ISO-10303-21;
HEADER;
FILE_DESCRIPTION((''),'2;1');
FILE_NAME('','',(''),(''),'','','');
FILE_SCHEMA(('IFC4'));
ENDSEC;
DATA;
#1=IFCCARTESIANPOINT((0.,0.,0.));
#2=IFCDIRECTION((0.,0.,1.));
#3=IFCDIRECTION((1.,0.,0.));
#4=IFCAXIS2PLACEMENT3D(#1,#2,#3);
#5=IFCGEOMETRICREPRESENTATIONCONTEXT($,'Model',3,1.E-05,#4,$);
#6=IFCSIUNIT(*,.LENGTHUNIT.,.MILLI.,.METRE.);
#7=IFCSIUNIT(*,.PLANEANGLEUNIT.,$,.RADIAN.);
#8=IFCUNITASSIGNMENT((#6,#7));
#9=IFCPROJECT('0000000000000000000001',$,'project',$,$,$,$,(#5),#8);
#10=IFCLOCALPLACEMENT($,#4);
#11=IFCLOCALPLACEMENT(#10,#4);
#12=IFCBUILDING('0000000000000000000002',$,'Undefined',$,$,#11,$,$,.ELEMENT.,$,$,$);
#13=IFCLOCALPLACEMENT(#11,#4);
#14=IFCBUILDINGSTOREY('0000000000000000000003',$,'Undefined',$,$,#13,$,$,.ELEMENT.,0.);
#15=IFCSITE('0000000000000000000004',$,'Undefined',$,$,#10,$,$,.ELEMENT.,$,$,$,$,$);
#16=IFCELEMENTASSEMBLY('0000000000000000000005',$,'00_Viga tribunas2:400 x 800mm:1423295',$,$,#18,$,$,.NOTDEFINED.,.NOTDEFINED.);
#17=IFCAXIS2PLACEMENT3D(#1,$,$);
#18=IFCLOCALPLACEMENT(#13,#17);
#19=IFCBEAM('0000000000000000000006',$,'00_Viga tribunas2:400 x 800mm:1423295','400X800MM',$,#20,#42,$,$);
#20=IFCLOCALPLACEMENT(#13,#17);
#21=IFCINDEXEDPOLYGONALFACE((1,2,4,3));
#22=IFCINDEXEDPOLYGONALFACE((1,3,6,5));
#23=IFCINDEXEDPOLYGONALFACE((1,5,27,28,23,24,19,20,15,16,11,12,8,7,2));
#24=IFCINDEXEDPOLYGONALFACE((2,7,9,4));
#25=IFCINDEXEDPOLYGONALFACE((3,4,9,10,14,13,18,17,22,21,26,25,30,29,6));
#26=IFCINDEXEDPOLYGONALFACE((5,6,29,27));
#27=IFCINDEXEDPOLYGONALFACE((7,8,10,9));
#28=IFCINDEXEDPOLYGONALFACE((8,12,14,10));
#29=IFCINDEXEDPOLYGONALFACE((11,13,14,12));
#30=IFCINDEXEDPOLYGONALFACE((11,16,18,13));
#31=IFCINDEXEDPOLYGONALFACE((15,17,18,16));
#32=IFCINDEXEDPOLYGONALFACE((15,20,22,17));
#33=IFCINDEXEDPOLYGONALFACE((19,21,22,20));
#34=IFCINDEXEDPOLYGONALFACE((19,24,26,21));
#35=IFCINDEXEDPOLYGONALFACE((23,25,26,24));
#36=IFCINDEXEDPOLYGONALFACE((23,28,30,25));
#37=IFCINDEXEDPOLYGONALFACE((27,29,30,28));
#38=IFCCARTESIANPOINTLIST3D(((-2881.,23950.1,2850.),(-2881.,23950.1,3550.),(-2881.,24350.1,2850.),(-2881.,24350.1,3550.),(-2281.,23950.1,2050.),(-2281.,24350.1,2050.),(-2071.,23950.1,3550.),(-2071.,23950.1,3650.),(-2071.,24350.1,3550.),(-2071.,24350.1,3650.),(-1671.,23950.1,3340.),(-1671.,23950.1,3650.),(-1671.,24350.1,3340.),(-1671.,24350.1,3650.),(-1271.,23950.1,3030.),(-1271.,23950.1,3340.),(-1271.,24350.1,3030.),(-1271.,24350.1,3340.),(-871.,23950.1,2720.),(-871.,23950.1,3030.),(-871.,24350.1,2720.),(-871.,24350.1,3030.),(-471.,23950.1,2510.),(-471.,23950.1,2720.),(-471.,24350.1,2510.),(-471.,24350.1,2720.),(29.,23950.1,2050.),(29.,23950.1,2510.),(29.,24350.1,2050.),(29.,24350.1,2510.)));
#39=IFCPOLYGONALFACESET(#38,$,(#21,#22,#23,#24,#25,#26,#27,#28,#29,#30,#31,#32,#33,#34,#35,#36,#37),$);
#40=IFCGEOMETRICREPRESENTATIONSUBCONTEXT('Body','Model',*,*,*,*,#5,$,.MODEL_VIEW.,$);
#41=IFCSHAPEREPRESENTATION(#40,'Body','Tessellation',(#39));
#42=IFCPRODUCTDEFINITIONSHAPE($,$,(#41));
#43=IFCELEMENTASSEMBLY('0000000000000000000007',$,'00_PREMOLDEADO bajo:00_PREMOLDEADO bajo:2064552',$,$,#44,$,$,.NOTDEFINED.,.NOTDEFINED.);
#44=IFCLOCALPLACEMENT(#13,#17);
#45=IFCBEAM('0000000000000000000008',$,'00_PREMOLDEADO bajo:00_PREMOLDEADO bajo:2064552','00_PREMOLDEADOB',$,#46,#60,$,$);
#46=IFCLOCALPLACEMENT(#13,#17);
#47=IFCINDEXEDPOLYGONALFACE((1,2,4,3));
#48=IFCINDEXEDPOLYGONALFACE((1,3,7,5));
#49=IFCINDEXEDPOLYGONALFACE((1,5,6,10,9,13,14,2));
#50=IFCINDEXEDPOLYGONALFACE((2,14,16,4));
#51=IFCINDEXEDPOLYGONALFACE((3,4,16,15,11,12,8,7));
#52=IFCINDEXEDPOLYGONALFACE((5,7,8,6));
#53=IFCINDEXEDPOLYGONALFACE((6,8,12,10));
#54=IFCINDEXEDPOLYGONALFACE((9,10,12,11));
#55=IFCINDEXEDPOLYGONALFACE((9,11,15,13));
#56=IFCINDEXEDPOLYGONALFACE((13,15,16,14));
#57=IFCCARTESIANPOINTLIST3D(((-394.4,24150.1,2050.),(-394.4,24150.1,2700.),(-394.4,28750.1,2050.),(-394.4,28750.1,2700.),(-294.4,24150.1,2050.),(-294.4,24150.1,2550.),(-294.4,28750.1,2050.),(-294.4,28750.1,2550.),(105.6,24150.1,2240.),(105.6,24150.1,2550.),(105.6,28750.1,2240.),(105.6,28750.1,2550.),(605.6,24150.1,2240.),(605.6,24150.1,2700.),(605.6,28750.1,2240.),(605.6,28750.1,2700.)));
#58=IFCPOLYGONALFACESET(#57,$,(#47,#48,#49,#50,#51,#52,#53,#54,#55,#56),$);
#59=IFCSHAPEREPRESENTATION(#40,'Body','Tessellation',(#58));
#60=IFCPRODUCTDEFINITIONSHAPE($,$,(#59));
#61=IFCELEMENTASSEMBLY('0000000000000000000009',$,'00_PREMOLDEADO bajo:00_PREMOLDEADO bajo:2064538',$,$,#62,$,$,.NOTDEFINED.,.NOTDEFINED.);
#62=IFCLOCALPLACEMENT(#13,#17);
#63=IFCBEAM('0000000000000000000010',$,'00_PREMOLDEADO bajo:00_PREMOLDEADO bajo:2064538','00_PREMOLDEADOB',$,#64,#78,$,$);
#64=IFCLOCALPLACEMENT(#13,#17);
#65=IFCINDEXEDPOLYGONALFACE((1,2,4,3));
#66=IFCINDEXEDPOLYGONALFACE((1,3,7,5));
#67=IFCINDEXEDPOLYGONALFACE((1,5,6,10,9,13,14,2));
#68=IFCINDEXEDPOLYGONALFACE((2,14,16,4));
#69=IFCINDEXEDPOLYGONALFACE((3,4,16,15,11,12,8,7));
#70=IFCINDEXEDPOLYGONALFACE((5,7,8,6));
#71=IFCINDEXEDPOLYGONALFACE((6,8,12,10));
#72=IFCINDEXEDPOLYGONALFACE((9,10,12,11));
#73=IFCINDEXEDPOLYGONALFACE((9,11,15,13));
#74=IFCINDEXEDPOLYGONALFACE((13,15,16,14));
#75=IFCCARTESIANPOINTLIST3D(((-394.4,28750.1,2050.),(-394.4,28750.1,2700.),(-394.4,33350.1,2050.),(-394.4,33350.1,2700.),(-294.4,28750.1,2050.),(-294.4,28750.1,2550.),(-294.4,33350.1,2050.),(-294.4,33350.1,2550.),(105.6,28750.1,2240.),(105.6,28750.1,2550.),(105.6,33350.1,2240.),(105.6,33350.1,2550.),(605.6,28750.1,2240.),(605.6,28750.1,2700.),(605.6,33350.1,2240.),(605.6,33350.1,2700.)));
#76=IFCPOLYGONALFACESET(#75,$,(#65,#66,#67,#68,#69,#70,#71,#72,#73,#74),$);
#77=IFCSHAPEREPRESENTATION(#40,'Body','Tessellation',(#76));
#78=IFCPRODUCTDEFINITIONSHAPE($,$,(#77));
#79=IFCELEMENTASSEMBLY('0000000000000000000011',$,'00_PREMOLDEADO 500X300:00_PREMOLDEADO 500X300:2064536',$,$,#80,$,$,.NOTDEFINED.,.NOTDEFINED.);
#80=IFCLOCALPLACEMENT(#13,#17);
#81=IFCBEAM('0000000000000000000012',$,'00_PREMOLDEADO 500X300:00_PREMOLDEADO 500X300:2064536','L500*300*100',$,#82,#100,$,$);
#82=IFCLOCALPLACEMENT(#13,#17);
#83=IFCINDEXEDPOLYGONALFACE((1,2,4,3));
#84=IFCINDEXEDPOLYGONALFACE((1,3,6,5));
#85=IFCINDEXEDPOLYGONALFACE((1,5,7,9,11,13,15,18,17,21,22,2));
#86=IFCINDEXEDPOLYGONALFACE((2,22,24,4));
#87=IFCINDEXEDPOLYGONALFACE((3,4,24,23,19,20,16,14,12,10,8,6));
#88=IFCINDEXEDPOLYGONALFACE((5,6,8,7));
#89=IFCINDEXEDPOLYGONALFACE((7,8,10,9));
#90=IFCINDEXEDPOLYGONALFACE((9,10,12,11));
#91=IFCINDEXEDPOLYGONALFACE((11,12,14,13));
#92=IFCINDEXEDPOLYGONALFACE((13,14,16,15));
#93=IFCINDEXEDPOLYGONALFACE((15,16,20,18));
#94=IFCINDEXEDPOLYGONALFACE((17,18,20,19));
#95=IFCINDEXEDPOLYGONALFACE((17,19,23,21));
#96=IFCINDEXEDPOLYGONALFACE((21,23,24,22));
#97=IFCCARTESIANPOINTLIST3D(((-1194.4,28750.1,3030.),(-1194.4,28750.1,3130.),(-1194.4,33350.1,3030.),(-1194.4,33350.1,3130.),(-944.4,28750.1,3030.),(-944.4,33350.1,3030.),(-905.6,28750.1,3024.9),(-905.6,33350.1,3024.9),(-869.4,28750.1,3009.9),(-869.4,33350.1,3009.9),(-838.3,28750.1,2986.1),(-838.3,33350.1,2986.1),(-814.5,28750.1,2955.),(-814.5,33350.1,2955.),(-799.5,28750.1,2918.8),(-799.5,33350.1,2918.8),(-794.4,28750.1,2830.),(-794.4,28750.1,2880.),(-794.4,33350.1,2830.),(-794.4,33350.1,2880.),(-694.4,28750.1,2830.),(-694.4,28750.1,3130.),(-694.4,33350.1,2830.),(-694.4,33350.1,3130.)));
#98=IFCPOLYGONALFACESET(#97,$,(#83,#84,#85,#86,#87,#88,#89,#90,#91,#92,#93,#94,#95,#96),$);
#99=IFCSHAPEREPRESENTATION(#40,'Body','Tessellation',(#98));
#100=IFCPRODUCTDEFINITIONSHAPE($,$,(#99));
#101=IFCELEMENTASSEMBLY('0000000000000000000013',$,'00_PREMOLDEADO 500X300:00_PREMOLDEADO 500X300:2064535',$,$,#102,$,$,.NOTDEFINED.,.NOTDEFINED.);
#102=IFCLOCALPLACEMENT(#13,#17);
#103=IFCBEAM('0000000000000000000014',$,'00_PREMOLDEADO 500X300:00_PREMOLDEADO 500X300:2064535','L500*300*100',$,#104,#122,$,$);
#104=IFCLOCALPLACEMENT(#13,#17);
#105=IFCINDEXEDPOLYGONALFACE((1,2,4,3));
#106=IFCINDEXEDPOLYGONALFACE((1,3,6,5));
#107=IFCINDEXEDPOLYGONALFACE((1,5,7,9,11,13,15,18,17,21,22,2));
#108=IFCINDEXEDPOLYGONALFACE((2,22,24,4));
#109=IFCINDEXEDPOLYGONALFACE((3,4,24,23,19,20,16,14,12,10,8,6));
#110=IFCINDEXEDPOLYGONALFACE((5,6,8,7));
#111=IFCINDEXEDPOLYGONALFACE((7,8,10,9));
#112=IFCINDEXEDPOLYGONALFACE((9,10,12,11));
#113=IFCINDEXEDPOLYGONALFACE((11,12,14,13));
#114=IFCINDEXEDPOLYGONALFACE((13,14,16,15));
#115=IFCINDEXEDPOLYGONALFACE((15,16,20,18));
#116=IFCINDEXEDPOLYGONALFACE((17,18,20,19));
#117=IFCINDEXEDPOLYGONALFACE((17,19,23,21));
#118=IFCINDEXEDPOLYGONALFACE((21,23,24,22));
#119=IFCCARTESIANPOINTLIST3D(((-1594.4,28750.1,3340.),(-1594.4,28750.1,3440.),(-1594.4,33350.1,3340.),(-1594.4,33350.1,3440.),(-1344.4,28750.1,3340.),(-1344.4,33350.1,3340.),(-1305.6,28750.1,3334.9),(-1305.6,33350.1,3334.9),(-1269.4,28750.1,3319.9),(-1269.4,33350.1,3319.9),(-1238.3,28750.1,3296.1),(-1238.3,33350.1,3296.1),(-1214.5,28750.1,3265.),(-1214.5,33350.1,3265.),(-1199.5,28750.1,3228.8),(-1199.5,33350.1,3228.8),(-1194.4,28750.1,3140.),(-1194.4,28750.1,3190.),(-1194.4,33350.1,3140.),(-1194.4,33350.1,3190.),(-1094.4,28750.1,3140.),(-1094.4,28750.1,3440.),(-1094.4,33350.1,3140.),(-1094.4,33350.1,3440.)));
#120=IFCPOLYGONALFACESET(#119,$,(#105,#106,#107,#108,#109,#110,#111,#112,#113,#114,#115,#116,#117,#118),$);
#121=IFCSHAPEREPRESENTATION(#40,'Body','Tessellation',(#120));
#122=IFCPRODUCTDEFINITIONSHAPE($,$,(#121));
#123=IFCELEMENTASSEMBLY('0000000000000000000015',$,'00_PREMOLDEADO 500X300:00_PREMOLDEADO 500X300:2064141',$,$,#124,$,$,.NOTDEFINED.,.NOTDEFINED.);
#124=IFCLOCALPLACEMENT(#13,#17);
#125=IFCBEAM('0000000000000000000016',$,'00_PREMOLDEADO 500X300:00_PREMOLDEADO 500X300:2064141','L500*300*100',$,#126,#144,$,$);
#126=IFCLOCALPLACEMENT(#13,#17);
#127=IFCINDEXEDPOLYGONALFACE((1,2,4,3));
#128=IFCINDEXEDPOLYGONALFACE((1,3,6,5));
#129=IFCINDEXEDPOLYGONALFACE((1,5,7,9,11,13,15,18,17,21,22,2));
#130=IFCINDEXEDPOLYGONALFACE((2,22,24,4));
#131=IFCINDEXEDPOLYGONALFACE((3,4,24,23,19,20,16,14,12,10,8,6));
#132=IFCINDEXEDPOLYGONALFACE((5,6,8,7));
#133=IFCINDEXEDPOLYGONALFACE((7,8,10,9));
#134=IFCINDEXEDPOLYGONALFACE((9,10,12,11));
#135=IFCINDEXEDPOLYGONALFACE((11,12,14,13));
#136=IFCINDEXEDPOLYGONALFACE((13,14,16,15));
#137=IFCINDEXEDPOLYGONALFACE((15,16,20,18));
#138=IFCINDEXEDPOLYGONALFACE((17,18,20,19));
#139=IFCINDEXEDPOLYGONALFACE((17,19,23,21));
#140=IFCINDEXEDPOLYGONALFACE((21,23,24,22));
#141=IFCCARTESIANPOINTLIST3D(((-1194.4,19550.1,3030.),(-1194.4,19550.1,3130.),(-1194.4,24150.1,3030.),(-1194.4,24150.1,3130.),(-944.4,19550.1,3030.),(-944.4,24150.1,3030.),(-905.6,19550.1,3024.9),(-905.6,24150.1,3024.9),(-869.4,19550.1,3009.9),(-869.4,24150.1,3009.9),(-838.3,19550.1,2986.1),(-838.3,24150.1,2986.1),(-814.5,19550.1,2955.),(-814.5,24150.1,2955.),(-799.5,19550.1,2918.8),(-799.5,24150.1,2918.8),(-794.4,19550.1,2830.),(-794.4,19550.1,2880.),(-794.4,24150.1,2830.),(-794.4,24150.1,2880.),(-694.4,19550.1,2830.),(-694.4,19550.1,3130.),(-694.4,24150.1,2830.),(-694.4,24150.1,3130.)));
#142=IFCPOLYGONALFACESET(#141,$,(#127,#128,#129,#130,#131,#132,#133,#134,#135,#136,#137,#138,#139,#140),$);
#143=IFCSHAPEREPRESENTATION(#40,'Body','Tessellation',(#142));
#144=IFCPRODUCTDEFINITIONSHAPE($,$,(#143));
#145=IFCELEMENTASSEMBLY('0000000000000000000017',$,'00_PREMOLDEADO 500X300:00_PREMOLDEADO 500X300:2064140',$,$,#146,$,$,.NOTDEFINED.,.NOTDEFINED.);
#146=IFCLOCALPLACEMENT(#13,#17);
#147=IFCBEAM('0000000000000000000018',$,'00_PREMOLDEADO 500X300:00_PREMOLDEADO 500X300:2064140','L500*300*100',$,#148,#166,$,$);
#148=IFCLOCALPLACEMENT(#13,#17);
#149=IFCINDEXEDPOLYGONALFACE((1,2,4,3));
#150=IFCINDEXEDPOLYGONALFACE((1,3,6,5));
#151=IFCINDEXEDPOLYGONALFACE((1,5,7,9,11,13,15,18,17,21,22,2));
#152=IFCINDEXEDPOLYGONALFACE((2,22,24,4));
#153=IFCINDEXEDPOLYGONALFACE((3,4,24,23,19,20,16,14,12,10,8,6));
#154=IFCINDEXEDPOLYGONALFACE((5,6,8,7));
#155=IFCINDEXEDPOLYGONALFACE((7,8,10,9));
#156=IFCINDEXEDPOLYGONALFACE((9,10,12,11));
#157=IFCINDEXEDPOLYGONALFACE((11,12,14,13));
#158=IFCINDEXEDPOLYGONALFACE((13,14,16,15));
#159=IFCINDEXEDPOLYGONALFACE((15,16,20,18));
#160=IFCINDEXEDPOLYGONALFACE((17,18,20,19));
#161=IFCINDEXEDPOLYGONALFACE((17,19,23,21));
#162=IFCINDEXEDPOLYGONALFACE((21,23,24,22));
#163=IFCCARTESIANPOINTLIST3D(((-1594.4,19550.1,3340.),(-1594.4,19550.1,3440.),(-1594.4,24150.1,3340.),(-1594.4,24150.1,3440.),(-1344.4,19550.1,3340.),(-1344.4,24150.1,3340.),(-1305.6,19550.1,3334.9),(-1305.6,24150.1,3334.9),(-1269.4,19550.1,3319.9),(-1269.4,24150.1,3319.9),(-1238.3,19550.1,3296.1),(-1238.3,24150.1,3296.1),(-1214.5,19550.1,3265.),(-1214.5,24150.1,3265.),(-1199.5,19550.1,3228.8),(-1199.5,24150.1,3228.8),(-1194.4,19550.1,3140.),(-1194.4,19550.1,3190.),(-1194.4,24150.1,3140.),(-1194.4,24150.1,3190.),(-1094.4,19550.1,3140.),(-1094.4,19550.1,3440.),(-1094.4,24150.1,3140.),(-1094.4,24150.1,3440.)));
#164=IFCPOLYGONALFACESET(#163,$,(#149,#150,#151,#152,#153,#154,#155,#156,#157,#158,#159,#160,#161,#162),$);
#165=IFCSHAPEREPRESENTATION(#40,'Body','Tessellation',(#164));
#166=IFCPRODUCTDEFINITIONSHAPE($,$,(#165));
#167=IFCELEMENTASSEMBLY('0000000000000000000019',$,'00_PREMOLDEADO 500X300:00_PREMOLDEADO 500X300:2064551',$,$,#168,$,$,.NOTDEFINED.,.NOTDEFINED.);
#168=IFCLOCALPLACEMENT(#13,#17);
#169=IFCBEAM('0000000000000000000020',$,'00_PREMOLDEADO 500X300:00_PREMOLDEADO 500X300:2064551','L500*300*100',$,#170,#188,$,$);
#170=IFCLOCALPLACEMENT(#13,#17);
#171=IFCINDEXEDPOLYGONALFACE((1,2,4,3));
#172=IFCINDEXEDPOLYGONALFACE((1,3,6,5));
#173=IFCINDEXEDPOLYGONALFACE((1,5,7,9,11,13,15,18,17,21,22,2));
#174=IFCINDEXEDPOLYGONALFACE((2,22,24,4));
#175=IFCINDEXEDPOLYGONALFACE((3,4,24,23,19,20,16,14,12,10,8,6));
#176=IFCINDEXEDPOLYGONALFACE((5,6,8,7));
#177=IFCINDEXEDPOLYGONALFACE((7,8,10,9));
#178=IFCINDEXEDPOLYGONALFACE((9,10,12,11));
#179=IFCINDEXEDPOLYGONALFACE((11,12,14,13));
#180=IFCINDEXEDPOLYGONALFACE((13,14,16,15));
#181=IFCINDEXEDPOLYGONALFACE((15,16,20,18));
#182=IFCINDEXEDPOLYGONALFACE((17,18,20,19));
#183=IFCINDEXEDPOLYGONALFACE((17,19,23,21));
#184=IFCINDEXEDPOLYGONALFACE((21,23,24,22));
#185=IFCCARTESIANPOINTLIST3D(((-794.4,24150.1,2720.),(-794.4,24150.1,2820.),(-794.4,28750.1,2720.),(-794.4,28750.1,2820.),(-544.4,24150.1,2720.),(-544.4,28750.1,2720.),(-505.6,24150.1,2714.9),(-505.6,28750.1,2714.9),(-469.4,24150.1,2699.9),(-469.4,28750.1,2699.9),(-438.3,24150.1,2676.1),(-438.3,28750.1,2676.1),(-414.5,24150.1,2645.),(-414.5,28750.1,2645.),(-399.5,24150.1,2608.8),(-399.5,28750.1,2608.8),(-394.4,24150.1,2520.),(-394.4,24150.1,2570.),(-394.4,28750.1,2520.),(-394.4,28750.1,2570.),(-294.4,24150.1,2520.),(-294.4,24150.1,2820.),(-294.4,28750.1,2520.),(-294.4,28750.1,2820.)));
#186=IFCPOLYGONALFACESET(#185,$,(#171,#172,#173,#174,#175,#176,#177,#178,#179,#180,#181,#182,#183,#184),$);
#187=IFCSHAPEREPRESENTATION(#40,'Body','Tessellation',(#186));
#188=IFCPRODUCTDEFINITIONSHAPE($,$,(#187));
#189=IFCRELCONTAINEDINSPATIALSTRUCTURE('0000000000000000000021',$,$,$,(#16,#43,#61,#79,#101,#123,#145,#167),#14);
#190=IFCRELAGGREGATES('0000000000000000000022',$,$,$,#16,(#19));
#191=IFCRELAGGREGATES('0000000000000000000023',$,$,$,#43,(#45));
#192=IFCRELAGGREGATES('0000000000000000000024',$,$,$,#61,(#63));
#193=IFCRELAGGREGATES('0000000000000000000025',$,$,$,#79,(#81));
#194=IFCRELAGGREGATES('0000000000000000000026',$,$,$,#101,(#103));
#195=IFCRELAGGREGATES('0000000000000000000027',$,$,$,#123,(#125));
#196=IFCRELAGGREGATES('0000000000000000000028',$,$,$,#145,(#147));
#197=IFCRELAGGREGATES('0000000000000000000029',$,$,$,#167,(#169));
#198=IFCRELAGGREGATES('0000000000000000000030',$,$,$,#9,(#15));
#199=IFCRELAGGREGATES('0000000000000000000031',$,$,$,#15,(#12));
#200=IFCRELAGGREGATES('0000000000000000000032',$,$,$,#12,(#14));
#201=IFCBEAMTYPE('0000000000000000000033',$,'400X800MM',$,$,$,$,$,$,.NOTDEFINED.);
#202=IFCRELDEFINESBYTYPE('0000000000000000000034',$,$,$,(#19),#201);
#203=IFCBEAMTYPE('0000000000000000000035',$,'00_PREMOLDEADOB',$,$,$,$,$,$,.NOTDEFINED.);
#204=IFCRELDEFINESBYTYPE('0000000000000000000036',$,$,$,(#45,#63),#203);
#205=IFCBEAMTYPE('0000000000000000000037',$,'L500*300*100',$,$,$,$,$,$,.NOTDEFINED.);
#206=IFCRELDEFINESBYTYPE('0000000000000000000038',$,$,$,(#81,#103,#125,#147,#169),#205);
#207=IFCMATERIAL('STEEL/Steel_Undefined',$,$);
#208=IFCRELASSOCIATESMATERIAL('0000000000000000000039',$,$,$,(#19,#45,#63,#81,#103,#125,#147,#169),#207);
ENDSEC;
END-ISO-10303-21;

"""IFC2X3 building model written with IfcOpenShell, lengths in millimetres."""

from ifc_helpers import new_model, si_unit, frame, origin_with_axes, origin_2d_with_axis, place, context, subcontext, project, spatial, polyline, l_section, outline, extrude, material, type_object, element, aggregate, save


model = new_model("IFC2X3")

# Units and contexts
model_context = context("Model", 3, precision=1e-05, world=origin_with_axes())
body_context = subcontext(model_context, "Body", "Model", "MODEL_VIEW")
ifc_project = project(units=[si_unit("LENGTHUNIT", "METRE", prefix="MILLI"), si_unit("PLANEANGLEUNIT", "RADIAN")], contexts=[model_context])

# Site, building, storey
site_placement = place(None, origin_with_axes())
site = spatial("IfcSite", under=ifc_project, at=site_placement, Name="Undefined", CompositionType="ELEMENT")
building_placement = place(site_placement, origin_with_axes())
building = spatial("IfcBuilding", under=site, at=building_placement, Name="Undefined", CompositionType="ELEMENT")
storey_placement = place(building_placement, origin_with_axes())
storey = spatial("IfcBuildingStorey", under=building, at=storey_placement, Name="Undefined", CompositionType="ELEMENT", Elevation=0.0)

# Shared definitions
ifc_material_1 = material(Name="STEEL/Steel_Undefined")

# Element assemblies, beams
beam_type_1 = type_object("IfcBeamType", Name="400X800MM", PredefinedType="NOTDEFINED")
assembly_1_placement = place(storey_placement, origin_with_axes())
assembly_1 = element("IfcElementAssembly", 1, at=assembly_1_placement, inside=storey, Name="00_Viga tribunas2:400 x 800mm:1423295", AssemblyPlace="NOTDEFINED", PredefinedType="NOTDEFINED")
beam_1_placement = place(assembly_1_placement, frame((-1426.0, 23950.1, 2850.0), z_axis=(-1.0, 0.0, 0.0), x_axis=(0.0, 1.0, 0.0)))
beam_1 = element("IfcBeam", 2, at=beam_1_placement, type_object=beam_type_1, material=ifc_material_1, Name="00_Viga tribunas2:400 x 800mm:1423295", Description="400X800MM", context=body_context, shape_type="SweptSolid", body=[
    extrude(outline(polyline([(-800.0, 855.0), (0.0, 1455.0), (700.0, 1455.0), (700.0, 645.0), (800.0, 645.0), (800.0, 245.0), (490.0, 245.0), (490.0, -155.0), (180.0, -155.0), (180.0, -555.0), (-130.0, -555.0), (-130.0, -955.0), (-340.0, -955.0), (-340.0, -1455.0), (-800.0, -1455.0), (-800.0, 855.0)])), frame((400.0, 0.0, 0.0), z_axis=(-1.0, 0.0, 0.0), x_axis=(0.0, -1.0, 0.0)), (0.0, 0.0, 1.0), 400.0),
])
aggregate(assembly_1, [beam_1])
assembly_2_placement = place(storey_placement, origin_with_axes())
assembly_2 = element("IfcElementAssembly", 3, at=assembly_2_placement, inside=storey, Name="00_PREMOLDEADO bajo:00_PREMOLDEADO bajo:2064552", AssemblyPlace="NOTDEFINED", PredefinedType="NOTDEFINED")
beam_type_2 = type_object("IfcBeamType", Name="00_PREMOLDEADOB", PredefinedType="NOTDEFINED")
beam_2_placement = place(assembly_2_placement, frame((105.6, 24150.1, 2375.0), z_axis=(1.0, 0.0, 0.0), x_axis=(0.0, 1.0, 0.0)))
beam_2 = element("IfcBeam", 4, at=beam_2_placement, type_object=beam_type_2, material=ifc_material_1, Name="00_PREMOLDEADO bajo:00_PREMOLDEADO bajo:2064552", Description="00_PREMOLDEADOB", context=body_context, shape_type="SweptSolid", body=[
    extrude(outline(polyline([(325.0, -400.0), (325.0, -500.0), (-325.0, -500.0), (-325.0, 500.0), (135.0, 500.0), (135.0, 0.0), (-175.0, 0.0), (-175.0, -400.0), (325.0, -400.0)])), frame((4600.0, 0.0, 0.0), z_axis=(-1.0, 0.0, 0.0), x_axis=(0.0, -1.0, 0.0)), (0.0, 0.0, 1.0), 4600.0),
])
aggregate(assembly_2, [beam_2])
assembly_3_placement = place(storey_placement, origin_with_axes())
assembly_3 = element("IfcElementAssembly", 5, at=assembly_3_placement, inside=storey, Name="00_PREMOLDEADO bajo:00_PREMOLDEADO bajo:2064538", AssemblyPlace="NOTDEFINED", PredefinedType="NOTDEFINED")
beam_3_placement = place(assembly_3_placement, frame((105.6, 28750.1, 2375.0), z_axis=(1.0, 0.0, 0.0), x_axis=(0.0, 1.0, 0.0)))
beam_3 = element("IfcBeam", 6, at=beam_3_placement, type_object=beam_type_2, material=ifc_material_1, Name="00_PREMOLDEADO bajo:00_PREMOLDEADO bajo:2064538", Description="00_PREMOLDEADOB", context=body_context, shape_type="SweptSolid", body=[
    extrude(outline(polyline([(325.0, -400.0), (325.0, -500.0), (-325.0, -500.0), (-325.0, 500.0), (135.0, 500.0), (135.0, 0.0), (-175.0, 0.0), (-175.0, -400.0), (325.0, -400.0)])), frame((4600.0, 0.0, 0.0), z_axis=(-1.0, 0.0, 0.0), x_axis=(0.0, -1.0, 0.0)), (0.0, 0.0, 1.0), 4600.0),
])
aggregate(assembly_3, [beam_3])
assembly_4_placement = place(storey_placement, origin_with_axes())
assembly_4 = element("IfcElementAssembly", 7, at=assembly_4_placement, inside=storey, Name="00_PREMOLDEADO 500X300:00_PREMOLDEADO 500X300:2064536", AssemblyPlace="NOTDEFINED", PredefinedType="NOTDEFINED")
beam_type_3 = type_object("IfcBeamType", Name="L500*300*100", PredefinedType="NOTDEFINED")
beam_4_placement = place(assembly_4_placement, frame((-944.4, 33350.1, 2980.0), z_axis=(-1.0, 0.0, 0.0), x_axis=(0.0, -1.0, 0.0)))
beam_4 = element("IfcBeam", 8, at=beam_4_placement, type_object=beam_type_3, material=ifc_material_1, Name="00_PREMOLDEADO 500X300:00_PREMOLDEADO 500X300:2064536", Description="L500*300*100", context=body_context, shape_type="SweptSolid", body=[
    extrude(l_section(Depth=500.0, Width=300.0, Thickness=100.0, FilletRadius=150.0, at=origin_2d_with_axis()), frame((4600.0, 0.0, 0.0), z_axis=(-1.0, 0.0, 0.0), x_axis=(0.0, -1.0, 0.0)), (0.0, 0.0, 1.0), 4600.0),
])
aggregate(assembly_4, [beam_4])
assembly_5_placement = place(storey_placement, origin_with_axes())
assembly_5 = element("IfcElementAssembly", 9, at=assembly_5_placement, inside=storey, Name="00_PREMOLDEADO 500X300:00_PREMOLDEADO 500X300:2064535", AssemblyPlace="NOTDEFINED", PredefinedType="NOTDEFINED")
beam_5_placement = place(assembly_5_placement, frame((-1344.4, 33350.1, 3290.0), z_axis=(-1.0, 0.0, 0.0), x_axis=(0.0, -1.0, 0.0)))
beam_5 = element("IfcBeam", 10, at=beam_5_placement, type_object=beam_type_3, material=ifc_material_1, Name="00_PREMOLDEADO 500X300:00_PREMOLDEADO 500X300:2064535", Description="L500*300*100", context=body_context, shape_type="SweptSolid", body=[
    extrude(l_section(Depth=500.0, Width=300.0, Thickness=100.0, FilletRadius=150.0, at=origin_2d_with_axis()), frame((4600.0, 0.0, 0.0), z_axis=(-1.0, 0.0, 0.0), x_axis=(0.0, -1.0, 0.0)), (0.0, 0.0, 1.0), 4600.0),
])
aggregate(assembly_5, [beam_5])
assembly_6_placement = place(storey_placement, origin_with_axes())
assembly_6 = element("IfcElementAssembly", 11, at=assembly_6_placement, inside=storey, Name="00_PREMOLDEADO 500X300:00_PREMOLDEADO 500X300:2064141", AssemblyPlace="NOTDEFINED", PredefinedType="NOTDEFINED")
beam_6_placement = place(assembly_6_placement, frame((-944.4, 24150.1, 2980.0), z_axis=(-1.0, 0.0, 0.0), x_axis=(0.0, -1.0, 0.0)))
beam_6 = element("IfcBeam", 12, at=beam_6_placement, type_object=beam_type_3, material=ifc_material_1, Name="00_PREMOLDEADO 500X300:00_PREMOLDEADO 500X300:2064141", Description="L500*300*100", context=body_context, shape_type="SweptSolid", body=[
    extrude(l_section(Depth=500.0, Width=300.0, Thickness=100.0, FilletRadius=150.0, at=origin_2d_with_axis()), frame((4600.0, 0.0, 0.0), z_axis=(-1.0, 0.0, 0.0), x_axis=(0.0, -1.0, 0.0)), (0.0, 0.0, 1.0), 4600.0),
])
aggregate(assembly_6, [beam_6])
assembly_7_placement = place(storey_placement, origin_with_axes())
assembly_7 = element("IfcElementAssembly", 13, at=assembly_7_placement, inside=storey, Name="00_PREMOLDEADO 500X300:00_PREMOLDEADO 500X300:2064140", AssemblyPlace="NOTDEFINED", PredefinedType="NOTDEFINED")
beam_7_placement = place(assembly_7_placement, frame((-1344.4, 24150.1, 3290.0), z_axis=(-1.0, 0.0, 0.0), x_axis=(0.0, -1.0, 0.0)))
beam_7 = element("IfcBeam", 14, at=beam_7_placement, type_object=beam_type_3, material=ifc_material_1, Name="00_PREMOLDEADO 500X300:00_PREMOLDEADO 500X300:2064140", Description="L500*300*100", context=body_context, shape_type="SweptSolid", body=[
    extrude(l_section(Depth=500.0, Width=300.0, Thickness=100.0, FilletRadius=150.0, at=origin_2d_with_axis()), frame((4600.0, 0.0, 0.0), z_axis=(-1.0, 0.0, 0.0), x_axis=(0.0, -1.0, 0.0)), (0.0, 0.0, 1.0), 4600.0),
])
aggregate(assembly_7, [beam_7])
assembly_8_placement = place(storey_placement, origin_with_axes())
assembly_8 = element("IfcElementAssembly", 15, at=assembly_8_placement, inside=storey, Name="00_PREMOLDEADO 500X300:00_PREMOLDEADO 500X300:2064551", AssemblyPlace="NOTDEFINED", PredefinedType="NOTDEFINED")
beam_8_placement = place(assembly_8_placement, frame((-544.4, 28750.1, 2670.0), z_axis=(-1.0, 0.0, 0.0), x_axis=(0.0, -1.0, 0.0)))
beam_8 = element("IfcBeam", 16, at=beam_8_placement, type_object=beam_type_3, material=ifc_material_1, Name="00_PREMOLDEADO 500X300:00_PREMOLDEADO 500X300:2064551", Description="L500*300*100", context=body_context, shape_type="SweptSolid", body=[
    extrude(l_section(Depth=500.0, Width=300.0, Thickness=100.0, FilletRadius=150.0, at=origin_2d_with_axis()), frame((4600.0, 0.0, 0.0), z_axis=(-1.0, 0.0, 0.0), x_axis=(0.0, -1.0, 0.0)), (0.0, 0.0, 1.0), 4600.0),
])
aggregate(assembly_8, [beam_8])

save(model, "model.ifc")
